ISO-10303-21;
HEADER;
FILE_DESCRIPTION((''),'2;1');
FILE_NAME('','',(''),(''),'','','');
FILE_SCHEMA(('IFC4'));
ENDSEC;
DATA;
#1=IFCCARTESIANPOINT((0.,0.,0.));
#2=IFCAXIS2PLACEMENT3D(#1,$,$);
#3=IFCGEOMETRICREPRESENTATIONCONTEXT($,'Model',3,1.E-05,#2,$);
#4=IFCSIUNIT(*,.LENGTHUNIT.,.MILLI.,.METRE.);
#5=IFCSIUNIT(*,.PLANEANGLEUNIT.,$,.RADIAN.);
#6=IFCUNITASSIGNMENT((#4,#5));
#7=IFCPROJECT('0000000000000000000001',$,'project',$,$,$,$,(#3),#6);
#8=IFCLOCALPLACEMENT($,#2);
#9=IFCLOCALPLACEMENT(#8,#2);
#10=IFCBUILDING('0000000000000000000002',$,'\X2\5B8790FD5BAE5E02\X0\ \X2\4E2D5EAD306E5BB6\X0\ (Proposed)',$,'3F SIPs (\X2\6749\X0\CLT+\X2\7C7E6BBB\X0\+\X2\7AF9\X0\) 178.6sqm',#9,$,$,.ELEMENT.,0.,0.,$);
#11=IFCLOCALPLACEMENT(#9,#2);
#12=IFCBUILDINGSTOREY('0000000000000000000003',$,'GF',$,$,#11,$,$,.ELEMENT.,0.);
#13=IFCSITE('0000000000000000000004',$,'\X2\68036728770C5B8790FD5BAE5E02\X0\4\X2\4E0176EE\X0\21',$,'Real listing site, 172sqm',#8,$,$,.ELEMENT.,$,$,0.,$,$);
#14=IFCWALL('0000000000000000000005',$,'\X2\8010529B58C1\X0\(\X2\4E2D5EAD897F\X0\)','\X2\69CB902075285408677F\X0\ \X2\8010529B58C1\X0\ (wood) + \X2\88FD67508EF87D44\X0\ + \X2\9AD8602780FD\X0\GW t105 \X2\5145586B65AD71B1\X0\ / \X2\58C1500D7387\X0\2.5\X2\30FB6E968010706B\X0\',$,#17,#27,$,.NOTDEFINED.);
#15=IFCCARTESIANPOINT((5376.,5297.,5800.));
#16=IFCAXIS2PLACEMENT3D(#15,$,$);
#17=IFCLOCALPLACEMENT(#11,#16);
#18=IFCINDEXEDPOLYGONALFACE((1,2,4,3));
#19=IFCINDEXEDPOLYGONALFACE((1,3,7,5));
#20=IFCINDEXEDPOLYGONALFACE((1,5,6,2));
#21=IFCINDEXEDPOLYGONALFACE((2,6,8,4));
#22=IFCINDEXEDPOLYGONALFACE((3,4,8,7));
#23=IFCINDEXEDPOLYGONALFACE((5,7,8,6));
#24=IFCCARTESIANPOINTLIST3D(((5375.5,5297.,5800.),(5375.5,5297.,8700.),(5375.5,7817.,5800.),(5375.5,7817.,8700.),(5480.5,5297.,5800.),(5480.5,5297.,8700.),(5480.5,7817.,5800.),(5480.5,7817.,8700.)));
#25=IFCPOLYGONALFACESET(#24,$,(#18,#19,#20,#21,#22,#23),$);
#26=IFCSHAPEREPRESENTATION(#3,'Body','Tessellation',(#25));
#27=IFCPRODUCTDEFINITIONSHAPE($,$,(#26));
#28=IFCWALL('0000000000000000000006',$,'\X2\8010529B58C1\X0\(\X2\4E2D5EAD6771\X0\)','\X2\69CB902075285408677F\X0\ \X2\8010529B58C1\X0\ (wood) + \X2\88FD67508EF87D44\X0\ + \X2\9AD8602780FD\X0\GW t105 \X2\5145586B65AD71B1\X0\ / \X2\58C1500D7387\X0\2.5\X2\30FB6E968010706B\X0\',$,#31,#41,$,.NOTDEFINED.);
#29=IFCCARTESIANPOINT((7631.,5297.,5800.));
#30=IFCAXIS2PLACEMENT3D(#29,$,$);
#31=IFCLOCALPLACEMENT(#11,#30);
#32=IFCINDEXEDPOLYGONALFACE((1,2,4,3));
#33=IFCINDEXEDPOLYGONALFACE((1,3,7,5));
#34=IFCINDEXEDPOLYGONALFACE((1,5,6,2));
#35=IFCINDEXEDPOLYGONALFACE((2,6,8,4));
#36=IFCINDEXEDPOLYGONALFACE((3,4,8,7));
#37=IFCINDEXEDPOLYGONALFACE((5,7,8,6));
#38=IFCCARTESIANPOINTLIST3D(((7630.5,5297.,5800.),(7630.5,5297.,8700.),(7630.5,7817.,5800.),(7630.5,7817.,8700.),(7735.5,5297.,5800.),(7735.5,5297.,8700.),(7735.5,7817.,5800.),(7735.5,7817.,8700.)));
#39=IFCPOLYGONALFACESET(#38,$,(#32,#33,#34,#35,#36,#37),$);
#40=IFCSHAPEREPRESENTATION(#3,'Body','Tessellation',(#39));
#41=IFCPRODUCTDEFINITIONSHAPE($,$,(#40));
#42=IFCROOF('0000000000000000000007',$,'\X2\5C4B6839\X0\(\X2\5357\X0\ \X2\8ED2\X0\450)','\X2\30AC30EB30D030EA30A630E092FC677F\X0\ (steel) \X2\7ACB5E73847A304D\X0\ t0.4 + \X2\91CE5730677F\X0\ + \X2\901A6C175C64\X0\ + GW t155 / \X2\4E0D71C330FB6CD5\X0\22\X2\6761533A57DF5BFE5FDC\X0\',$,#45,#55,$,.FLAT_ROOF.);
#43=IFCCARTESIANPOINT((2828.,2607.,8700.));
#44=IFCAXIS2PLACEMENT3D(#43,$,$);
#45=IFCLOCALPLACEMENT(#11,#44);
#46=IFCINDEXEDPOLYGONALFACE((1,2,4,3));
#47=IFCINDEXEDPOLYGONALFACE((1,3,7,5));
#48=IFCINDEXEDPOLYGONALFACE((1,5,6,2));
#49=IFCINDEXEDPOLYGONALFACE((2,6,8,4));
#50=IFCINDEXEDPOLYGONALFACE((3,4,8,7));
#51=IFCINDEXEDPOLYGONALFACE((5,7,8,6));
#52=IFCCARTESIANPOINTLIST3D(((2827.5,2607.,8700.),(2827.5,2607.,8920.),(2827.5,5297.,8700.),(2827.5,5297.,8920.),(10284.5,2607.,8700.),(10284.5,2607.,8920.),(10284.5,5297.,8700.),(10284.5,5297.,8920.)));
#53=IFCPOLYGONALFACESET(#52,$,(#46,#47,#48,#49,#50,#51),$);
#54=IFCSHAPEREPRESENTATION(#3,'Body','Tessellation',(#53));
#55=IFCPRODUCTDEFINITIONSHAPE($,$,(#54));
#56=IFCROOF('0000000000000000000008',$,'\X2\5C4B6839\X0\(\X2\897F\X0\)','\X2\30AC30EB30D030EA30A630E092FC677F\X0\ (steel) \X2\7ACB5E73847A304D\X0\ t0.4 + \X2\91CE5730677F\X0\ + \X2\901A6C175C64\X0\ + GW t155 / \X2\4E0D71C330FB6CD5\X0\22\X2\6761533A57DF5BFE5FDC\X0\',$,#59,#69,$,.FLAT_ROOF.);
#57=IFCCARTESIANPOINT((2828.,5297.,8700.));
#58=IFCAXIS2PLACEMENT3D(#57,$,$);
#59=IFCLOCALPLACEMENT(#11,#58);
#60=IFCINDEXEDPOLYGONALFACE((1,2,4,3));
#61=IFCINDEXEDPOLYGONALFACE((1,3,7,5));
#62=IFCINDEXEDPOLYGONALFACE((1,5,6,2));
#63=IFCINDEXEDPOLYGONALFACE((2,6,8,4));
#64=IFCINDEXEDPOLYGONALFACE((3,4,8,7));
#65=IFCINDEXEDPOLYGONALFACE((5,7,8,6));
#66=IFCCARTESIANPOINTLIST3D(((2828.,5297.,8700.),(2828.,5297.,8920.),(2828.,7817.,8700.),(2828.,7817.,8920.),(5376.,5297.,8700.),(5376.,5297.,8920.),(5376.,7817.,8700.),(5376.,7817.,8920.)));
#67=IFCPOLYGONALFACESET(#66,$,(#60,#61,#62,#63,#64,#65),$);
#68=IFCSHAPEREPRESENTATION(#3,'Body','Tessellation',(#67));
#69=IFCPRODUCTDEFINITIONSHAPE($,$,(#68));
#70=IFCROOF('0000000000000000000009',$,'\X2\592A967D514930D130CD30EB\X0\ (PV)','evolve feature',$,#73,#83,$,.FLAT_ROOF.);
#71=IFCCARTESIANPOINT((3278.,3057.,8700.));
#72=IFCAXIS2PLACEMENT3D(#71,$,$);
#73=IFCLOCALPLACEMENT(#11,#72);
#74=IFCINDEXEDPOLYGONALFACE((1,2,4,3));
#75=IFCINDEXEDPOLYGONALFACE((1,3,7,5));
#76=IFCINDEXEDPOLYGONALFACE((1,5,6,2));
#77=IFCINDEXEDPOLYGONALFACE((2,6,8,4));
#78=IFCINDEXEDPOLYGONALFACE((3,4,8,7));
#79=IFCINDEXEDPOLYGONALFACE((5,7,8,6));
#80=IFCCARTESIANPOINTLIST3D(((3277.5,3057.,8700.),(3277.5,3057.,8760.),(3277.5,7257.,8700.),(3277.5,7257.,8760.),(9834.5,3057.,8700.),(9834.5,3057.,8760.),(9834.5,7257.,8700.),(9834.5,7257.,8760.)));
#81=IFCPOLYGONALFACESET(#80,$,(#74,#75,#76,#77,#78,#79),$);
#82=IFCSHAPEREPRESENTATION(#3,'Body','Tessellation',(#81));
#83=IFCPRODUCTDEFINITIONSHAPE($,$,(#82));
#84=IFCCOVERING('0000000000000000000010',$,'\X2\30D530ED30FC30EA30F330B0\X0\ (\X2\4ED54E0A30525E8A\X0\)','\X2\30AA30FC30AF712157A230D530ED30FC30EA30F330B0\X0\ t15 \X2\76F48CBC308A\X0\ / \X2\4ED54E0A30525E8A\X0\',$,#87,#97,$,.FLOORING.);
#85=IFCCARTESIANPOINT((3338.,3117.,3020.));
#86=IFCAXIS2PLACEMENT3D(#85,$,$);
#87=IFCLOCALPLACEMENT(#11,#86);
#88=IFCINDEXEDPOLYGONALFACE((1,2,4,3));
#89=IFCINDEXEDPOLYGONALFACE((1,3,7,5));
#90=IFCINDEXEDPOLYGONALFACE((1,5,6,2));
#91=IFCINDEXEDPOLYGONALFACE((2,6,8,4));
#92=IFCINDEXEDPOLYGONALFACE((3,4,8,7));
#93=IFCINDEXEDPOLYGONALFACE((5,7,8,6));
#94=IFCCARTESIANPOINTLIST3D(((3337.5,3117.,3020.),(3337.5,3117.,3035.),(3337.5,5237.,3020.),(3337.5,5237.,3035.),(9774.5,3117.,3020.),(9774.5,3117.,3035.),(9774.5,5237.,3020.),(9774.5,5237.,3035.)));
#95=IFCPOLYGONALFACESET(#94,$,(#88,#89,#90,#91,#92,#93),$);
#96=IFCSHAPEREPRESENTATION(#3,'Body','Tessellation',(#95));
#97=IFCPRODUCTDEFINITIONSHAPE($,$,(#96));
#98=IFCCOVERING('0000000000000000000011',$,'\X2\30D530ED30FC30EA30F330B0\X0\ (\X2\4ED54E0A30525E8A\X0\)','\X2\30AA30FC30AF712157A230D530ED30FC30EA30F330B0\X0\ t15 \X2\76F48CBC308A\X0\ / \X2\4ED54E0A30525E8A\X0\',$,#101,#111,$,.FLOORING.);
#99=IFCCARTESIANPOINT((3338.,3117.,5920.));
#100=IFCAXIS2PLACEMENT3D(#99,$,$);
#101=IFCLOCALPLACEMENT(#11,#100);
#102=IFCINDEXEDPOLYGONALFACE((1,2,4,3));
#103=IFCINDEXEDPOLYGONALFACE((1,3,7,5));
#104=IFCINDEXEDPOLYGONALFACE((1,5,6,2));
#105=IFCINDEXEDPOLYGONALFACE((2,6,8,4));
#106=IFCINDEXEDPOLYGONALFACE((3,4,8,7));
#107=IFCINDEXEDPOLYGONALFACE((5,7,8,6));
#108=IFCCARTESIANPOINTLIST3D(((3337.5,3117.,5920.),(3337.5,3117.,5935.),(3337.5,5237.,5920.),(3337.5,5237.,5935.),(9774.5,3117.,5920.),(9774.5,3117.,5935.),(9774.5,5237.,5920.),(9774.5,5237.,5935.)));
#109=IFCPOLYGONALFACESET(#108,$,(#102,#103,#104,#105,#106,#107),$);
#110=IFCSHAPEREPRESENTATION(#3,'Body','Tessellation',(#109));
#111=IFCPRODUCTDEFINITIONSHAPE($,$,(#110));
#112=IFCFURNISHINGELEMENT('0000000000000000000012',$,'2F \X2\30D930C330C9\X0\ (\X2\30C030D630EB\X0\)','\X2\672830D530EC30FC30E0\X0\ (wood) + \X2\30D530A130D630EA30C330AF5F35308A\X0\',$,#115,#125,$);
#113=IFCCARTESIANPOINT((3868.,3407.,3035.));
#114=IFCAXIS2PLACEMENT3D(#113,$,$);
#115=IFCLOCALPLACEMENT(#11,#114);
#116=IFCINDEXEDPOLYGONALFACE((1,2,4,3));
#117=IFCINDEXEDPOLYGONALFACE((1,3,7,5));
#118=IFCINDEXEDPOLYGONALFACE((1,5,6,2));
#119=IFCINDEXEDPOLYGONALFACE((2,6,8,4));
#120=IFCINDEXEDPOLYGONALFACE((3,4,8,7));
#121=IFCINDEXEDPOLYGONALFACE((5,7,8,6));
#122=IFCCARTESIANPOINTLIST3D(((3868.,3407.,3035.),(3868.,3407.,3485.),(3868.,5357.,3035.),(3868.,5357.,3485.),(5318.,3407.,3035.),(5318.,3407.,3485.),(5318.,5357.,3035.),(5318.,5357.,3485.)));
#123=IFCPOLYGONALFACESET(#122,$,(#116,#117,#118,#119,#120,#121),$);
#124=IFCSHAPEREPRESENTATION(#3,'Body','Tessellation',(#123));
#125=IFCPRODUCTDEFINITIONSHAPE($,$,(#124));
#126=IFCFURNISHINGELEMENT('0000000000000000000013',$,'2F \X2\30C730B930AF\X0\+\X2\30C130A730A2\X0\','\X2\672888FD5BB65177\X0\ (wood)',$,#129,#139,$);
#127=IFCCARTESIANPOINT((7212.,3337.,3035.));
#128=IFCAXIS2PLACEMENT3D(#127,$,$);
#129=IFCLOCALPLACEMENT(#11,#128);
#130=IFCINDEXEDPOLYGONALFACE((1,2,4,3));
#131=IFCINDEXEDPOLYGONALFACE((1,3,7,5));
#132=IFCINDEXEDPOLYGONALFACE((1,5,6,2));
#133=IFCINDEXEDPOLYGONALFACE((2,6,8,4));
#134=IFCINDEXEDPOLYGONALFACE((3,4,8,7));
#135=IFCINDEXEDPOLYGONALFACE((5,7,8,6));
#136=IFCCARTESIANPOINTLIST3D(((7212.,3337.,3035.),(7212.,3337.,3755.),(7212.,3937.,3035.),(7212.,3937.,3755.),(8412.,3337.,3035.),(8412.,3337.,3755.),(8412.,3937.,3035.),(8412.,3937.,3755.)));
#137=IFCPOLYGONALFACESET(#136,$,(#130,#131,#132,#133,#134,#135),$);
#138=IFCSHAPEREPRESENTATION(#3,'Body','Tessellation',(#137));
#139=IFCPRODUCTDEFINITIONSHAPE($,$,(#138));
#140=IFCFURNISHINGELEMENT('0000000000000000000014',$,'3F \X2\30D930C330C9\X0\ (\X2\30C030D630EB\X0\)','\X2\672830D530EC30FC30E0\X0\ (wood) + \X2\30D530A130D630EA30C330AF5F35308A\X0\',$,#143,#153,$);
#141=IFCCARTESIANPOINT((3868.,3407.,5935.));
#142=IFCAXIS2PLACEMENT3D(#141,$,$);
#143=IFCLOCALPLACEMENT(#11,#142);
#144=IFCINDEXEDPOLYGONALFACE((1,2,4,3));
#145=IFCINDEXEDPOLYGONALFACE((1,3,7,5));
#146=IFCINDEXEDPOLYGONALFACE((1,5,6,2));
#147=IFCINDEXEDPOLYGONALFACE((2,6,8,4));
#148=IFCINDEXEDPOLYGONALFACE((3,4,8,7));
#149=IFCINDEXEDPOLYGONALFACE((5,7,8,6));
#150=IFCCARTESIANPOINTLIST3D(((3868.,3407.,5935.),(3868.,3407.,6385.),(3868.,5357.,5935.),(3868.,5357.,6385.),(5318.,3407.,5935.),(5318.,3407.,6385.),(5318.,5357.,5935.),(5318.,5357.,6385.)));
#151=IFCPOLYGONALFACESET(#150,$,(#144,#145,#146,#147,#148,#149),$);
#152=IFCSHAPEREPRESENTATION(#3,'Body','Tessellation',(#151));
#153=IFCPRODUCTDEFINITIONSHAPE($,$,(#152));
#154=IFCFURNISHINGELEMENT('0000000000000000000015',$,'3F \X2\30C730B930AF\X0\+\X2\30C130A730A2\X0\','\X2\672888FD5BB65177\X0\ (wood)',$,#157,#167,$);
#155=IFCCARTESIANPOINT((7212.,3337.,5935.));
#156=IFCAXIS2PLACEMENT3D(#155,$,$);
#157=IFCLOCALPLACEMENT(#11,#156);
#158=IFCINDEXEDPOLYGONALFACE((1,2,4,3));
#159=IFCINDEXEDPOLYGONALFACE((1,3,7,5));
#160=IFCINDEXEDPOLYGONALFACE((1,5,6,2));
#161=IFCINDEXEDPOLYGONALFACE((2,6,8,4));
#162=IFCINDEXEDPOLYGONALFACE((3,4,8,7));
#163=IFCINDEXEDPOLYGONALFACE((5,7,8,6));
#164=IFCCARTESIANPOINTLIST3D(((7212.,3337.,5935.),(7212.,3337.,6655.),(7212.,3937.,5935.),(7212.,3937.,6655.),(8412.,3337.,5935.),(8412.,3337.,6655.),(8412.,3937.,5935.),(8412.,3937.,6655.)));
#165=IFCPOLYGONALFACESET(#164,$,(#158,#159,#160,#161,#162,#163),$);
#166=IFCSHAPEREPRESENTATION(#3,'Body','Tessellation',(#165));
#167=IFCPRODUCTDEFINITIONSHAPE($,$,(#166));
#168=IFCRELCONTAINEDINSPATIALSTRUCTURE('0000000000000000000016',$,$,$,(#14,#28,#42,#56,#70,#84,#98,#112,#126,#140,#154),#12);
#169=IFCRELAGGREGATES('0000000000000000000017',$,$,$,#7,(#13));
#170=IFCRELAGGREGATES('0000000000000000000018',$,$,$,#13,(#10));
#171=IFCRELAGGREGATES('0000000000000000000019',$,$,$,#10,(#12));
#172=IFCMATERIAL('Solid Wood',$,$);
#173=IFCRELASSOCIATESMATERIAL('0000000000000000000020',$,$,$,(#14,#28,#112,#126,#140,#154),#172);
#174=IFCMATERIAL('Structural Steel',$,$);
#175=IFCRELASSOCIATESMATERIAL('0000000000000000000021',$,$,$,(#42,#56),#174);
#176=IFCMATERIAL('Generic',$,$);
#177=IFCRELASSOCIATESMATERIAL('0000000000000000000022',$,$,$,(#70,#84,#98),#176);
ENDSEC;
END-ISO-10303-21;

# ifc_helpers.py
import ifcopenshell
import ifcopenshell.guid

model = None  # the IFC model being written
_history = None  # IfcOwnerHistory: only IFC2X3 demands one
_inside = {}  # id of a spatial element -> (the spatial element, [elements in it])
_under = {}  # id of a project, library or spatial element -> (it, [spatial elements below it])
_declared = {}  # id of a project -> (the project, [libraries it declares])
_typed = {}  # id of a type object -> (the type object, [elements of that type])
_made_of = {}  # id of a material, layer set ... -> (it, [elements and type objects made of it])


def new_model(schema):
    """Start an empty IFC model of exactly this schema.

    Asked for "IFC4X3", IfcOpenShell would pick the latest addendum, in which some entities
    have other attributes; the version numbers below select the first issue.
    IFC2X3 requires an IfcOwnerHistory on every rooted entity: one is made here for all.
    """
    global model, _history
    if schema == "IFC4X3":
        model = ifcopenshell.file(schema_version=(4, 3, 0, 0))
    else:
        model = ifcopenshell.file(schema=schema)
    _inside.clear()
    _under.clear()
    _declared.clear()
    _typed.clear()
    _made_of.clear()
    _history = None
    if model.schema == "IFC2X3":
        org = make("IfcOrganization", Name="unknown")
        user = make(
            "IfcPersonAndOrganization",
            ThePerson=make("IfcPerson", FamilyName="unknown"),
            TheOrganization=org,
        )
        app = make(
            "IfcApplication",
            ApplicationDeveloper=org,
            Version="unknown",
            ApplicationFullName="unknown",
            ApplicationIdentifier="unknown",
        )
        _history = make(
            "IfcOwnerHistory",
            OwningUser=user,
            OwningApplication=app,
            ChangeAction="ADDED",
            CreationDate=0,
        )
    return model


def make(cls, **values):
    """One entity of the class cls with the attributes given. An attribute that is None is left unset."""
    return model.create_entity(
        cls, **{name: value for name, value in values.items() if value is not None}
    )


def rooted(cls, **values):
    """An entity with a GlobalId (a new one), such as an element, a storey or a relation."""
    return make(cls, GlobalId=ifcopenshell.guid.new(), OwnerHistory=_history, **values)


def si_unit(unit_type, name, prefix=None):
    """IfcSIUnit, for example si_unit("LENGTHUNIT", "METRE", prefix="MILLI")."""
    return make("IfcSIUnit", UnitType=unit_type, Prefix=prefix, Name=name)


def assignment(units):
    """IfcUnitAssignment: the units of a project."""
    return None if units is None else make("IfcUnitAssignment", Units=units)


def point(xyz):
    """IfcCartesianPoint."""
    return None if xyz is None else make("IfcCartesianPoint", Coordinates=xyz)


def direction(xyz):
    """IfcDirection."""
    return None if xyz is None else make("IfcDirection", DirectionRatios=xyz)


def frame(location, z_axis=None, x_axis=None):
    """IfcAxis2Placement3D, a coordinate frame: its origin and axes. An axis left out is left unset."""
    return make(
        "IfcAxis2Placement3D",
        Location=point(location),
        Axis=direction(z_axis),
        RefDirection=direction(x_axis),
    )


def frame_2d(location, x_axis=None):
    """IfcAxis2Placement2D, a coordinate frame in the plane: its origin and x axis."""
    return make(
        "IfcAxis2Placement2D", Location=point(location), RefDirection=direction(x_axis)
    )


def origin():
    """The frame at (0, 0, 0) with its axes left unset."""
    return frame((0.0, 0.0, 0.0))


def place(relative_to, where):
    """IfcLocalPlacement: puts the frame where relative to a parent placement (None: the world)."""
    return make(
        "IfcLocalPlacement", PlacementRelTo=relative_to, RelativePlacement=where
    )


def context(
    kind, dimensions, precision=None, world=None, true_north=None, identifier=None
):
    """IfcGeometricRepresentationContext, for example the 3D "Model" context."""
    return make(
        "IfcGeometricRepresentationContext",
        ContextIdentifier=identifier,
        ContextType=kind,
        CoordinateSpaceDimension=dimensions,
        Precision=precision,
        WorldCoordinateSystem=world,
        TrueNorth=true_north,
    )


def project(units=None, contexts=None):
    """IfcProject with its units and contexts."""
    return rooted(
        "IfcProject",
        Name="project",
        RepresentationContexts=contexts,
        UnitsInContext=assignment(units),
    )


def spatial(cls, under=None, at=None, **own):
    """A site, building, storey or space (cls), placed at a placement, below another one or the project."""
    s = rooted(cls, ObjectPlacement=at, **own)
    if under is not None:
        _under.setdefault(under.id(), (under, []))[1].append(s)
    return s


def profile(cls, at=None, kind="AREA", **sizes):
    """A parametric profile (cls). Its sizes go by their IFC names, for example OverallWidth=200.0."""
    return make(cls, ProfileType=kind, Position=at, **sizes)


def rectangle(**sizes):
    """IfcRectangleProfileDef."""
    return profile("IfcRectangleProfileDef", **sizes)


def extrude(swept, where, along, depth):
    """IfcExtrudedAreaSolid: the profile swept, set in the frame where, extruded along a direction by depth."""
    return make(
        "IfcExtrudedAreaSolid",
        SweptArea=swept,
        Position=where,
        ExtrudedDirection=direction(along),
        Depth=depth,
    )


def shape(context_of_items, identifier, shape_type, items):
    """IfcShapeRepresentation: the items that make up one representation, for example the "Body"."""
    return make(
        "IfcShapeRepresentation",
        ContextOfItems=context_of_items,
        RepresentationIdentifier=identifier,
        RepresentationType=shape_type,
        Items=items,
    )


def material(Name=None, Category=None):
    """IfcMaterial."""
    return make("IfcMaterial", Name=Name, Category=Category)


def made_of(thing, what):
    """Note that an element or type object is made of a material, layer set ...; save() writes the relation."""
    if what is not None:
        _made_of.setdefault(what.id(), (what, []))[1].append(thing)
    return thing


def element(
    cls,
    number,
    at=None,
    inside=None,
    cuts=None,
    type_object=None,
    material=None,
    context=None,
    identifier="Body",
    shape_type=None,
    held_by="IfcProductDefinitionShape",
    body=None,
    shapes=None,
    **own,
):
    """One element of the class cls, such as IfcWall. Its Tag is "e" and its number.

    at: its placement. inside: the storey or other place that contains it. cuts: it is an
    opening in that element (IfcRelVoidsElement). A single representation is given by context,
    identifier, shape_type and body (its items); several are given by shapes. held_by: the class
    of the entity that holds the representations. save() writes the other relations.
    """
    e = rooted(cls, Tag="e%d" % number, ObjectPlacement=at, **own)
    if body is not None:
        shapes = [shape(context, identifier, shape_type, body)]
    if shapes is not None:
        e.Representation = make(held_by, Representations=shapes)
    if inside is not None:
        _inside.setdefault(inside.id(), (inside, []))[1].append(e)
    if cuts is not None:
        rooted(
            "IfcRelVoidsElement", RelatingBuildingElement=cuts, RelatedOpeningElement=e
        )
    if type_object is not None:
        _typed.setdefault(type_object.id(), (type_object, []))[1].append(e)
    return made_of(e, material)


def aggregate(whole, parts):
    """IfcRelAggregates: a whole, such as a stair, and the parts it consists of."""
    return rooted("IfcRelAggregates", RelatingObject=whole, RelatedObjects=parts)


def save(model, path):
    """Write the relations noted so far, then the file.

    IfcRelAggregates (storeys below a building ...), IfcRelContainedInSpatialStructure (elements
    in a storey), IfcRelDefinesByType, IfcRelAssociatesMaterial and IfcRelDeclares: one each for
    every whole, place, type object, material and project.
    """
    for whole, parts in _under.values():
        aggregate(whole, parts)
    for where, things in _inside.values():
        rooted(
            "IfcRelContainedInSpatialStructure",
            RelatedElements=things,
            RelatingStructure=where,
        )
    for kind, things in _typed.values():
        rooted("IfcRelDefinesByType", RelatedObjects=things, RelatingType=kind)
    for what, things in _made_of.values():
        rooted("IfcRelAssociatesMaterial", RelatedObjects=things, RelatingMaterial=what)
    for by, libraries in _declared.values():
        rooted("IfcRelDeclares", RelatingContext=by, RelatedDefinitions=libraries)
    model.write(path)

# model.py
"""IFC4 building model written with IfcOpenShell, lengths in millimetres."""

from ifc_helpers import new_model, si_unit, frame, frame_2d, origin, place, context, project, spatial, rectangle, extrude, material, element, save


model = new_model("IFC4")

# Units and contexts
model_context = context("Model", 3, precision=1e-05, world=origin())
ifc_project = project(units=[si_unit("LENGTHUNIT", "METRE", prefix="MILLI"), si_unit("PLANEANGLEUNIT", "RADIAN")], contexts=[model_context])

# Site, building, storey
site_placement = place(None, origin())
site = spatial("IfcSite", under=ifc_project, at=site_placement, Name="栃木県宇都宮市4丁目21", ObjectType="Real listing site, 172sqm", CompositionType="ELEMENT", RefElevation=0.0)
building_placement = place(site_placement, origin())
building = spatial("IfcBuilding", under=site, at=building_placement, Name="宇都宮市 中庭の家 (Proposed)", ObjectType="3F SIPs (杉CLT+籾殻+竹) 178.6sqm", CompositionType="ELEMENT", ElevationOfRefHeight=0.0, ElevationOfTerrain=0.0)
storey_placement = place(building_placement, origin())
storey = spatial("IfcBuildingStorey", under=building, at=storey_placement, Name="GF", CompositionType="ELEMENT", Elevation=0.0)

# Shared definitions
ifc_material_1 = material(Name="Solid Wood")

# Walls
wall_1_placement = place(storey_placement, frame((5376.0, 5297.0, 5800.0)))
element("IfcWall", 1, at=wall_1_placement, inside=storey, material=ifc_material_1, Name="耐力壁(中庭西)", Description="構造用合板 耐力壁 (wood) + 製材軸組 + 高性能GW t105 充填断熱 / 壁倍率2.5・準耐火", PredefinedType="NOTDEFINED", context=model_context, shape_type="SweptSolid", body=[
    extrude(rectangle(XDim=105.0, YDim=2520.0, at=frame_2d((52.0, 1260.0))), frame((5376.0, 5297.0, 5800.0)), (0.0, 0.0, 1.0), 2900.0),
])
wall_2_placement = place(storey_placement, frame((7631.0, 5297.0, 5800.0)))
element("IfcWall", 2, at=wall_2_placement, inside=storey, material=ifc_material_1, Name="耐力壁(中庭東)", Description="構造用合板 耐力壁 (wood) + 製材軸組 + 高性能GW t105 充填断熱 / 壁倍率2.5・準耐火", PredefinedType="NOTDEFINED", context=model_context, shape_type="SweptSolid", body=[
    extrude(rectangle(XDim=105.0, YDim=2520.0, at=frame_2d((52.0, 1260.0))), frame((7631.0, 5297.0, 5800.0)), (0.0, 0.0, 1.0), 2900.0),
])

# Roofs
ifc_material_2 = material(Name="Structural Steel")
roof_1_placement = place(storey_placement, frame((2828.0, 2607.0, 8700.0)))
element("IfcRoof", 3, at=roof_1_placement, inside=storey, material=ifc_material_2, Name="屋根(南 軒450)", Description="ガルバリウム鋼板 (steel) 立平葺き t0.4 + 野地板 + 通気層 + GW t155 / 不燃・法22条区域対応", PredefinedType="FLAT_ROOF", context=model_context, shape_type="SweptSolid", body=[
    extrude(rectangle(XDim=7457.0, YDim=2690.0, at=frame_2d((3728.0, 1345.0))), frame((2828.0, 2607.0, 8700.0)), (0.0, 0.0, 1.0), 220.0),
])
roof_2_placement = place(storey_placement, frame((2828.0, 5297.0, 8700.0)))
element("IfcRoof", 4, at=roof_2_placement, inside=storey, material=ifc_material_2, Name="屋根(西)", Description="ガルバリウム鋼板 (steel) 立平葺き t0.4 + 野地板 + 通気層 + GW t155 / 不燃・法22条区域対応", PredefinedType="FLAT_ROOF", context=model_context, shape_type="SweptSolid", body=[
    extrude(rectangle(XDim=2548.0, YDim=2520.0, at=frame_2d((1274.0, 1260.0))), frame((2828.0, 5297.0, 8700.0)), (0.0, 0.0, 1.0), 220.0),
])
ifc_material_3 = material(Name="Generic")
roof_3_placement = place(storey_placement, frame((3278.0, 3057.0, 8700.0)))
element("IfcRoof", 5, at=roof_3_placement, inside=storey, material=ifc_material_3, Name="太陽光パネル (PV)", Description="evolve feature", PredefinedType="FLAT_ROOF", context=model_context, shape_type="SweptSolid", body=[
    extrude(rectangle(XDim=6557.0, YDim=4200.0, at=frame_2d((3278.0, 2100.0))), frame((3278.0, 3057.0, 8700.0)), (0.0, 0.0, 1.0), 60.0),
])

# Coverings
covering_1_placement = place(storey_placement, frame((3338.0, 3117.0, 3020.0)))
element("IfcCovering", 6, at=covering_1_placement, inside=storey, material=ifc_material_3, Name="フローリング (仕上げ床)", Description="オーク無垢フローリング t15 直貼り / 仕上げ床", PredefinedType="FLOORING", context=model_context, shape_type="SweptSolid", body=[
    extrude(rectangle(XDim=6437.0, YDim=2120.0, at=frame_2d((3218.0, 1060.0))), frame((3338.0, 3117.0, 3020.0)), (0.0, 0.0, 1.0), 15.0),
])
covering_2_placement = place(storey_placement, frame((3338.0, 3117.0, 5920.0)))
element("IfcCovering", 7, at=covering_2_placement, inside=storey, material=ifc_material_3, Name="フローリング (仕上げ床)", Description="オーク無垢フローリング t15 直貼り / 仕上げ床", PredefinedType="FLOORING", context=model_context, shape_type="SweptSolid", body=[
    extrude(rectangle(XDim=6437.0, YDim=2120.0, at=frame_2d((3218.0, 1060.0))), frame((3338.0, 3117.0, 5920.0)), (0.0, 0.0, 1.0), 15.0),
])

# Furnishing elements
furnishing_1_placement = place(storey_placement, frame((3868.0, 3407.0, 3035.0)))
element("IfcFurnishingElement", 8, at=furnishing_1_placement, inside=storey, material=ifc_material_1, Name="2F ベッド (ダブル)", Description="木フレーム (wood) + ファブリック張り", context=model_context, shape_type="SweptSolid", body=[
    extrude(rectangle(XDim=1450.0, YDim=1950.0, at=frame_2d((725.0, 975.0))), frame((3868.0, 3407.0, 3035.0)), (0.0, 0.0, 1.0), 450.0),
])
furnishing_2_placement = place(storey_placement, frame((7212.0, 3337.0, 3035.0)))
element("IfcFurnishingElement", 9, at=furnishing_2_placement, inside=storey, material=ifc_material_1, Name="2F デスク+チェア", Description="木製家具 (wood)", context=model_context, shape_type="SweptSolid", body=[
    extrude(rectangle(XDim=1200.0, YDim=600.0, at=frame_2d((600.0, 300.0))), frame((7212.0, 3337.0, 3035.0)), (0.0, 0.0, 1.0), 720.0),
])
furnishing_3_placement = place(storey_placement, frame((3868.0, 3407.0, 5935.0)))
element("IfcFurnishingElement", 10, at=furnishing_3_placement, inside=storey, material=ifc_material_1, Name="3F ベッド (ダブル)", Description="木フレーム (wood) + ファブリック張り", context=model_context, shape_type="SweptSolid", body=[
    extrude(rectangle(XDim=1450.0, YDim=1950.0, at=frame_2d((725.0, 975.0))), frame((3868.0, 3407.0, 5935.0)), (0.0, 0.0, 1.0), 450.0),
])
furnishing_4_placement = place(storey_placement, frame((7212.0, 3337.0, 5935.0)))
element("IfcFurnishingElement", 11, at=furnishing_4_placement, inside=storey, material=ifc_material_1, Name="3F デスク+チェア", Description="木製家具 (wood)", context=model_context, shape_type="SweptSolid", body=[
    extrude(rectangle(XDim=1200.0, YDim=600.0, at=frame_2d((600.0, 300.0))), frame((7212.0, 3337.0, 5935.0)), (0.0, 0.0, 1.0), 720.0),
])

save(model, "model.ifc")
